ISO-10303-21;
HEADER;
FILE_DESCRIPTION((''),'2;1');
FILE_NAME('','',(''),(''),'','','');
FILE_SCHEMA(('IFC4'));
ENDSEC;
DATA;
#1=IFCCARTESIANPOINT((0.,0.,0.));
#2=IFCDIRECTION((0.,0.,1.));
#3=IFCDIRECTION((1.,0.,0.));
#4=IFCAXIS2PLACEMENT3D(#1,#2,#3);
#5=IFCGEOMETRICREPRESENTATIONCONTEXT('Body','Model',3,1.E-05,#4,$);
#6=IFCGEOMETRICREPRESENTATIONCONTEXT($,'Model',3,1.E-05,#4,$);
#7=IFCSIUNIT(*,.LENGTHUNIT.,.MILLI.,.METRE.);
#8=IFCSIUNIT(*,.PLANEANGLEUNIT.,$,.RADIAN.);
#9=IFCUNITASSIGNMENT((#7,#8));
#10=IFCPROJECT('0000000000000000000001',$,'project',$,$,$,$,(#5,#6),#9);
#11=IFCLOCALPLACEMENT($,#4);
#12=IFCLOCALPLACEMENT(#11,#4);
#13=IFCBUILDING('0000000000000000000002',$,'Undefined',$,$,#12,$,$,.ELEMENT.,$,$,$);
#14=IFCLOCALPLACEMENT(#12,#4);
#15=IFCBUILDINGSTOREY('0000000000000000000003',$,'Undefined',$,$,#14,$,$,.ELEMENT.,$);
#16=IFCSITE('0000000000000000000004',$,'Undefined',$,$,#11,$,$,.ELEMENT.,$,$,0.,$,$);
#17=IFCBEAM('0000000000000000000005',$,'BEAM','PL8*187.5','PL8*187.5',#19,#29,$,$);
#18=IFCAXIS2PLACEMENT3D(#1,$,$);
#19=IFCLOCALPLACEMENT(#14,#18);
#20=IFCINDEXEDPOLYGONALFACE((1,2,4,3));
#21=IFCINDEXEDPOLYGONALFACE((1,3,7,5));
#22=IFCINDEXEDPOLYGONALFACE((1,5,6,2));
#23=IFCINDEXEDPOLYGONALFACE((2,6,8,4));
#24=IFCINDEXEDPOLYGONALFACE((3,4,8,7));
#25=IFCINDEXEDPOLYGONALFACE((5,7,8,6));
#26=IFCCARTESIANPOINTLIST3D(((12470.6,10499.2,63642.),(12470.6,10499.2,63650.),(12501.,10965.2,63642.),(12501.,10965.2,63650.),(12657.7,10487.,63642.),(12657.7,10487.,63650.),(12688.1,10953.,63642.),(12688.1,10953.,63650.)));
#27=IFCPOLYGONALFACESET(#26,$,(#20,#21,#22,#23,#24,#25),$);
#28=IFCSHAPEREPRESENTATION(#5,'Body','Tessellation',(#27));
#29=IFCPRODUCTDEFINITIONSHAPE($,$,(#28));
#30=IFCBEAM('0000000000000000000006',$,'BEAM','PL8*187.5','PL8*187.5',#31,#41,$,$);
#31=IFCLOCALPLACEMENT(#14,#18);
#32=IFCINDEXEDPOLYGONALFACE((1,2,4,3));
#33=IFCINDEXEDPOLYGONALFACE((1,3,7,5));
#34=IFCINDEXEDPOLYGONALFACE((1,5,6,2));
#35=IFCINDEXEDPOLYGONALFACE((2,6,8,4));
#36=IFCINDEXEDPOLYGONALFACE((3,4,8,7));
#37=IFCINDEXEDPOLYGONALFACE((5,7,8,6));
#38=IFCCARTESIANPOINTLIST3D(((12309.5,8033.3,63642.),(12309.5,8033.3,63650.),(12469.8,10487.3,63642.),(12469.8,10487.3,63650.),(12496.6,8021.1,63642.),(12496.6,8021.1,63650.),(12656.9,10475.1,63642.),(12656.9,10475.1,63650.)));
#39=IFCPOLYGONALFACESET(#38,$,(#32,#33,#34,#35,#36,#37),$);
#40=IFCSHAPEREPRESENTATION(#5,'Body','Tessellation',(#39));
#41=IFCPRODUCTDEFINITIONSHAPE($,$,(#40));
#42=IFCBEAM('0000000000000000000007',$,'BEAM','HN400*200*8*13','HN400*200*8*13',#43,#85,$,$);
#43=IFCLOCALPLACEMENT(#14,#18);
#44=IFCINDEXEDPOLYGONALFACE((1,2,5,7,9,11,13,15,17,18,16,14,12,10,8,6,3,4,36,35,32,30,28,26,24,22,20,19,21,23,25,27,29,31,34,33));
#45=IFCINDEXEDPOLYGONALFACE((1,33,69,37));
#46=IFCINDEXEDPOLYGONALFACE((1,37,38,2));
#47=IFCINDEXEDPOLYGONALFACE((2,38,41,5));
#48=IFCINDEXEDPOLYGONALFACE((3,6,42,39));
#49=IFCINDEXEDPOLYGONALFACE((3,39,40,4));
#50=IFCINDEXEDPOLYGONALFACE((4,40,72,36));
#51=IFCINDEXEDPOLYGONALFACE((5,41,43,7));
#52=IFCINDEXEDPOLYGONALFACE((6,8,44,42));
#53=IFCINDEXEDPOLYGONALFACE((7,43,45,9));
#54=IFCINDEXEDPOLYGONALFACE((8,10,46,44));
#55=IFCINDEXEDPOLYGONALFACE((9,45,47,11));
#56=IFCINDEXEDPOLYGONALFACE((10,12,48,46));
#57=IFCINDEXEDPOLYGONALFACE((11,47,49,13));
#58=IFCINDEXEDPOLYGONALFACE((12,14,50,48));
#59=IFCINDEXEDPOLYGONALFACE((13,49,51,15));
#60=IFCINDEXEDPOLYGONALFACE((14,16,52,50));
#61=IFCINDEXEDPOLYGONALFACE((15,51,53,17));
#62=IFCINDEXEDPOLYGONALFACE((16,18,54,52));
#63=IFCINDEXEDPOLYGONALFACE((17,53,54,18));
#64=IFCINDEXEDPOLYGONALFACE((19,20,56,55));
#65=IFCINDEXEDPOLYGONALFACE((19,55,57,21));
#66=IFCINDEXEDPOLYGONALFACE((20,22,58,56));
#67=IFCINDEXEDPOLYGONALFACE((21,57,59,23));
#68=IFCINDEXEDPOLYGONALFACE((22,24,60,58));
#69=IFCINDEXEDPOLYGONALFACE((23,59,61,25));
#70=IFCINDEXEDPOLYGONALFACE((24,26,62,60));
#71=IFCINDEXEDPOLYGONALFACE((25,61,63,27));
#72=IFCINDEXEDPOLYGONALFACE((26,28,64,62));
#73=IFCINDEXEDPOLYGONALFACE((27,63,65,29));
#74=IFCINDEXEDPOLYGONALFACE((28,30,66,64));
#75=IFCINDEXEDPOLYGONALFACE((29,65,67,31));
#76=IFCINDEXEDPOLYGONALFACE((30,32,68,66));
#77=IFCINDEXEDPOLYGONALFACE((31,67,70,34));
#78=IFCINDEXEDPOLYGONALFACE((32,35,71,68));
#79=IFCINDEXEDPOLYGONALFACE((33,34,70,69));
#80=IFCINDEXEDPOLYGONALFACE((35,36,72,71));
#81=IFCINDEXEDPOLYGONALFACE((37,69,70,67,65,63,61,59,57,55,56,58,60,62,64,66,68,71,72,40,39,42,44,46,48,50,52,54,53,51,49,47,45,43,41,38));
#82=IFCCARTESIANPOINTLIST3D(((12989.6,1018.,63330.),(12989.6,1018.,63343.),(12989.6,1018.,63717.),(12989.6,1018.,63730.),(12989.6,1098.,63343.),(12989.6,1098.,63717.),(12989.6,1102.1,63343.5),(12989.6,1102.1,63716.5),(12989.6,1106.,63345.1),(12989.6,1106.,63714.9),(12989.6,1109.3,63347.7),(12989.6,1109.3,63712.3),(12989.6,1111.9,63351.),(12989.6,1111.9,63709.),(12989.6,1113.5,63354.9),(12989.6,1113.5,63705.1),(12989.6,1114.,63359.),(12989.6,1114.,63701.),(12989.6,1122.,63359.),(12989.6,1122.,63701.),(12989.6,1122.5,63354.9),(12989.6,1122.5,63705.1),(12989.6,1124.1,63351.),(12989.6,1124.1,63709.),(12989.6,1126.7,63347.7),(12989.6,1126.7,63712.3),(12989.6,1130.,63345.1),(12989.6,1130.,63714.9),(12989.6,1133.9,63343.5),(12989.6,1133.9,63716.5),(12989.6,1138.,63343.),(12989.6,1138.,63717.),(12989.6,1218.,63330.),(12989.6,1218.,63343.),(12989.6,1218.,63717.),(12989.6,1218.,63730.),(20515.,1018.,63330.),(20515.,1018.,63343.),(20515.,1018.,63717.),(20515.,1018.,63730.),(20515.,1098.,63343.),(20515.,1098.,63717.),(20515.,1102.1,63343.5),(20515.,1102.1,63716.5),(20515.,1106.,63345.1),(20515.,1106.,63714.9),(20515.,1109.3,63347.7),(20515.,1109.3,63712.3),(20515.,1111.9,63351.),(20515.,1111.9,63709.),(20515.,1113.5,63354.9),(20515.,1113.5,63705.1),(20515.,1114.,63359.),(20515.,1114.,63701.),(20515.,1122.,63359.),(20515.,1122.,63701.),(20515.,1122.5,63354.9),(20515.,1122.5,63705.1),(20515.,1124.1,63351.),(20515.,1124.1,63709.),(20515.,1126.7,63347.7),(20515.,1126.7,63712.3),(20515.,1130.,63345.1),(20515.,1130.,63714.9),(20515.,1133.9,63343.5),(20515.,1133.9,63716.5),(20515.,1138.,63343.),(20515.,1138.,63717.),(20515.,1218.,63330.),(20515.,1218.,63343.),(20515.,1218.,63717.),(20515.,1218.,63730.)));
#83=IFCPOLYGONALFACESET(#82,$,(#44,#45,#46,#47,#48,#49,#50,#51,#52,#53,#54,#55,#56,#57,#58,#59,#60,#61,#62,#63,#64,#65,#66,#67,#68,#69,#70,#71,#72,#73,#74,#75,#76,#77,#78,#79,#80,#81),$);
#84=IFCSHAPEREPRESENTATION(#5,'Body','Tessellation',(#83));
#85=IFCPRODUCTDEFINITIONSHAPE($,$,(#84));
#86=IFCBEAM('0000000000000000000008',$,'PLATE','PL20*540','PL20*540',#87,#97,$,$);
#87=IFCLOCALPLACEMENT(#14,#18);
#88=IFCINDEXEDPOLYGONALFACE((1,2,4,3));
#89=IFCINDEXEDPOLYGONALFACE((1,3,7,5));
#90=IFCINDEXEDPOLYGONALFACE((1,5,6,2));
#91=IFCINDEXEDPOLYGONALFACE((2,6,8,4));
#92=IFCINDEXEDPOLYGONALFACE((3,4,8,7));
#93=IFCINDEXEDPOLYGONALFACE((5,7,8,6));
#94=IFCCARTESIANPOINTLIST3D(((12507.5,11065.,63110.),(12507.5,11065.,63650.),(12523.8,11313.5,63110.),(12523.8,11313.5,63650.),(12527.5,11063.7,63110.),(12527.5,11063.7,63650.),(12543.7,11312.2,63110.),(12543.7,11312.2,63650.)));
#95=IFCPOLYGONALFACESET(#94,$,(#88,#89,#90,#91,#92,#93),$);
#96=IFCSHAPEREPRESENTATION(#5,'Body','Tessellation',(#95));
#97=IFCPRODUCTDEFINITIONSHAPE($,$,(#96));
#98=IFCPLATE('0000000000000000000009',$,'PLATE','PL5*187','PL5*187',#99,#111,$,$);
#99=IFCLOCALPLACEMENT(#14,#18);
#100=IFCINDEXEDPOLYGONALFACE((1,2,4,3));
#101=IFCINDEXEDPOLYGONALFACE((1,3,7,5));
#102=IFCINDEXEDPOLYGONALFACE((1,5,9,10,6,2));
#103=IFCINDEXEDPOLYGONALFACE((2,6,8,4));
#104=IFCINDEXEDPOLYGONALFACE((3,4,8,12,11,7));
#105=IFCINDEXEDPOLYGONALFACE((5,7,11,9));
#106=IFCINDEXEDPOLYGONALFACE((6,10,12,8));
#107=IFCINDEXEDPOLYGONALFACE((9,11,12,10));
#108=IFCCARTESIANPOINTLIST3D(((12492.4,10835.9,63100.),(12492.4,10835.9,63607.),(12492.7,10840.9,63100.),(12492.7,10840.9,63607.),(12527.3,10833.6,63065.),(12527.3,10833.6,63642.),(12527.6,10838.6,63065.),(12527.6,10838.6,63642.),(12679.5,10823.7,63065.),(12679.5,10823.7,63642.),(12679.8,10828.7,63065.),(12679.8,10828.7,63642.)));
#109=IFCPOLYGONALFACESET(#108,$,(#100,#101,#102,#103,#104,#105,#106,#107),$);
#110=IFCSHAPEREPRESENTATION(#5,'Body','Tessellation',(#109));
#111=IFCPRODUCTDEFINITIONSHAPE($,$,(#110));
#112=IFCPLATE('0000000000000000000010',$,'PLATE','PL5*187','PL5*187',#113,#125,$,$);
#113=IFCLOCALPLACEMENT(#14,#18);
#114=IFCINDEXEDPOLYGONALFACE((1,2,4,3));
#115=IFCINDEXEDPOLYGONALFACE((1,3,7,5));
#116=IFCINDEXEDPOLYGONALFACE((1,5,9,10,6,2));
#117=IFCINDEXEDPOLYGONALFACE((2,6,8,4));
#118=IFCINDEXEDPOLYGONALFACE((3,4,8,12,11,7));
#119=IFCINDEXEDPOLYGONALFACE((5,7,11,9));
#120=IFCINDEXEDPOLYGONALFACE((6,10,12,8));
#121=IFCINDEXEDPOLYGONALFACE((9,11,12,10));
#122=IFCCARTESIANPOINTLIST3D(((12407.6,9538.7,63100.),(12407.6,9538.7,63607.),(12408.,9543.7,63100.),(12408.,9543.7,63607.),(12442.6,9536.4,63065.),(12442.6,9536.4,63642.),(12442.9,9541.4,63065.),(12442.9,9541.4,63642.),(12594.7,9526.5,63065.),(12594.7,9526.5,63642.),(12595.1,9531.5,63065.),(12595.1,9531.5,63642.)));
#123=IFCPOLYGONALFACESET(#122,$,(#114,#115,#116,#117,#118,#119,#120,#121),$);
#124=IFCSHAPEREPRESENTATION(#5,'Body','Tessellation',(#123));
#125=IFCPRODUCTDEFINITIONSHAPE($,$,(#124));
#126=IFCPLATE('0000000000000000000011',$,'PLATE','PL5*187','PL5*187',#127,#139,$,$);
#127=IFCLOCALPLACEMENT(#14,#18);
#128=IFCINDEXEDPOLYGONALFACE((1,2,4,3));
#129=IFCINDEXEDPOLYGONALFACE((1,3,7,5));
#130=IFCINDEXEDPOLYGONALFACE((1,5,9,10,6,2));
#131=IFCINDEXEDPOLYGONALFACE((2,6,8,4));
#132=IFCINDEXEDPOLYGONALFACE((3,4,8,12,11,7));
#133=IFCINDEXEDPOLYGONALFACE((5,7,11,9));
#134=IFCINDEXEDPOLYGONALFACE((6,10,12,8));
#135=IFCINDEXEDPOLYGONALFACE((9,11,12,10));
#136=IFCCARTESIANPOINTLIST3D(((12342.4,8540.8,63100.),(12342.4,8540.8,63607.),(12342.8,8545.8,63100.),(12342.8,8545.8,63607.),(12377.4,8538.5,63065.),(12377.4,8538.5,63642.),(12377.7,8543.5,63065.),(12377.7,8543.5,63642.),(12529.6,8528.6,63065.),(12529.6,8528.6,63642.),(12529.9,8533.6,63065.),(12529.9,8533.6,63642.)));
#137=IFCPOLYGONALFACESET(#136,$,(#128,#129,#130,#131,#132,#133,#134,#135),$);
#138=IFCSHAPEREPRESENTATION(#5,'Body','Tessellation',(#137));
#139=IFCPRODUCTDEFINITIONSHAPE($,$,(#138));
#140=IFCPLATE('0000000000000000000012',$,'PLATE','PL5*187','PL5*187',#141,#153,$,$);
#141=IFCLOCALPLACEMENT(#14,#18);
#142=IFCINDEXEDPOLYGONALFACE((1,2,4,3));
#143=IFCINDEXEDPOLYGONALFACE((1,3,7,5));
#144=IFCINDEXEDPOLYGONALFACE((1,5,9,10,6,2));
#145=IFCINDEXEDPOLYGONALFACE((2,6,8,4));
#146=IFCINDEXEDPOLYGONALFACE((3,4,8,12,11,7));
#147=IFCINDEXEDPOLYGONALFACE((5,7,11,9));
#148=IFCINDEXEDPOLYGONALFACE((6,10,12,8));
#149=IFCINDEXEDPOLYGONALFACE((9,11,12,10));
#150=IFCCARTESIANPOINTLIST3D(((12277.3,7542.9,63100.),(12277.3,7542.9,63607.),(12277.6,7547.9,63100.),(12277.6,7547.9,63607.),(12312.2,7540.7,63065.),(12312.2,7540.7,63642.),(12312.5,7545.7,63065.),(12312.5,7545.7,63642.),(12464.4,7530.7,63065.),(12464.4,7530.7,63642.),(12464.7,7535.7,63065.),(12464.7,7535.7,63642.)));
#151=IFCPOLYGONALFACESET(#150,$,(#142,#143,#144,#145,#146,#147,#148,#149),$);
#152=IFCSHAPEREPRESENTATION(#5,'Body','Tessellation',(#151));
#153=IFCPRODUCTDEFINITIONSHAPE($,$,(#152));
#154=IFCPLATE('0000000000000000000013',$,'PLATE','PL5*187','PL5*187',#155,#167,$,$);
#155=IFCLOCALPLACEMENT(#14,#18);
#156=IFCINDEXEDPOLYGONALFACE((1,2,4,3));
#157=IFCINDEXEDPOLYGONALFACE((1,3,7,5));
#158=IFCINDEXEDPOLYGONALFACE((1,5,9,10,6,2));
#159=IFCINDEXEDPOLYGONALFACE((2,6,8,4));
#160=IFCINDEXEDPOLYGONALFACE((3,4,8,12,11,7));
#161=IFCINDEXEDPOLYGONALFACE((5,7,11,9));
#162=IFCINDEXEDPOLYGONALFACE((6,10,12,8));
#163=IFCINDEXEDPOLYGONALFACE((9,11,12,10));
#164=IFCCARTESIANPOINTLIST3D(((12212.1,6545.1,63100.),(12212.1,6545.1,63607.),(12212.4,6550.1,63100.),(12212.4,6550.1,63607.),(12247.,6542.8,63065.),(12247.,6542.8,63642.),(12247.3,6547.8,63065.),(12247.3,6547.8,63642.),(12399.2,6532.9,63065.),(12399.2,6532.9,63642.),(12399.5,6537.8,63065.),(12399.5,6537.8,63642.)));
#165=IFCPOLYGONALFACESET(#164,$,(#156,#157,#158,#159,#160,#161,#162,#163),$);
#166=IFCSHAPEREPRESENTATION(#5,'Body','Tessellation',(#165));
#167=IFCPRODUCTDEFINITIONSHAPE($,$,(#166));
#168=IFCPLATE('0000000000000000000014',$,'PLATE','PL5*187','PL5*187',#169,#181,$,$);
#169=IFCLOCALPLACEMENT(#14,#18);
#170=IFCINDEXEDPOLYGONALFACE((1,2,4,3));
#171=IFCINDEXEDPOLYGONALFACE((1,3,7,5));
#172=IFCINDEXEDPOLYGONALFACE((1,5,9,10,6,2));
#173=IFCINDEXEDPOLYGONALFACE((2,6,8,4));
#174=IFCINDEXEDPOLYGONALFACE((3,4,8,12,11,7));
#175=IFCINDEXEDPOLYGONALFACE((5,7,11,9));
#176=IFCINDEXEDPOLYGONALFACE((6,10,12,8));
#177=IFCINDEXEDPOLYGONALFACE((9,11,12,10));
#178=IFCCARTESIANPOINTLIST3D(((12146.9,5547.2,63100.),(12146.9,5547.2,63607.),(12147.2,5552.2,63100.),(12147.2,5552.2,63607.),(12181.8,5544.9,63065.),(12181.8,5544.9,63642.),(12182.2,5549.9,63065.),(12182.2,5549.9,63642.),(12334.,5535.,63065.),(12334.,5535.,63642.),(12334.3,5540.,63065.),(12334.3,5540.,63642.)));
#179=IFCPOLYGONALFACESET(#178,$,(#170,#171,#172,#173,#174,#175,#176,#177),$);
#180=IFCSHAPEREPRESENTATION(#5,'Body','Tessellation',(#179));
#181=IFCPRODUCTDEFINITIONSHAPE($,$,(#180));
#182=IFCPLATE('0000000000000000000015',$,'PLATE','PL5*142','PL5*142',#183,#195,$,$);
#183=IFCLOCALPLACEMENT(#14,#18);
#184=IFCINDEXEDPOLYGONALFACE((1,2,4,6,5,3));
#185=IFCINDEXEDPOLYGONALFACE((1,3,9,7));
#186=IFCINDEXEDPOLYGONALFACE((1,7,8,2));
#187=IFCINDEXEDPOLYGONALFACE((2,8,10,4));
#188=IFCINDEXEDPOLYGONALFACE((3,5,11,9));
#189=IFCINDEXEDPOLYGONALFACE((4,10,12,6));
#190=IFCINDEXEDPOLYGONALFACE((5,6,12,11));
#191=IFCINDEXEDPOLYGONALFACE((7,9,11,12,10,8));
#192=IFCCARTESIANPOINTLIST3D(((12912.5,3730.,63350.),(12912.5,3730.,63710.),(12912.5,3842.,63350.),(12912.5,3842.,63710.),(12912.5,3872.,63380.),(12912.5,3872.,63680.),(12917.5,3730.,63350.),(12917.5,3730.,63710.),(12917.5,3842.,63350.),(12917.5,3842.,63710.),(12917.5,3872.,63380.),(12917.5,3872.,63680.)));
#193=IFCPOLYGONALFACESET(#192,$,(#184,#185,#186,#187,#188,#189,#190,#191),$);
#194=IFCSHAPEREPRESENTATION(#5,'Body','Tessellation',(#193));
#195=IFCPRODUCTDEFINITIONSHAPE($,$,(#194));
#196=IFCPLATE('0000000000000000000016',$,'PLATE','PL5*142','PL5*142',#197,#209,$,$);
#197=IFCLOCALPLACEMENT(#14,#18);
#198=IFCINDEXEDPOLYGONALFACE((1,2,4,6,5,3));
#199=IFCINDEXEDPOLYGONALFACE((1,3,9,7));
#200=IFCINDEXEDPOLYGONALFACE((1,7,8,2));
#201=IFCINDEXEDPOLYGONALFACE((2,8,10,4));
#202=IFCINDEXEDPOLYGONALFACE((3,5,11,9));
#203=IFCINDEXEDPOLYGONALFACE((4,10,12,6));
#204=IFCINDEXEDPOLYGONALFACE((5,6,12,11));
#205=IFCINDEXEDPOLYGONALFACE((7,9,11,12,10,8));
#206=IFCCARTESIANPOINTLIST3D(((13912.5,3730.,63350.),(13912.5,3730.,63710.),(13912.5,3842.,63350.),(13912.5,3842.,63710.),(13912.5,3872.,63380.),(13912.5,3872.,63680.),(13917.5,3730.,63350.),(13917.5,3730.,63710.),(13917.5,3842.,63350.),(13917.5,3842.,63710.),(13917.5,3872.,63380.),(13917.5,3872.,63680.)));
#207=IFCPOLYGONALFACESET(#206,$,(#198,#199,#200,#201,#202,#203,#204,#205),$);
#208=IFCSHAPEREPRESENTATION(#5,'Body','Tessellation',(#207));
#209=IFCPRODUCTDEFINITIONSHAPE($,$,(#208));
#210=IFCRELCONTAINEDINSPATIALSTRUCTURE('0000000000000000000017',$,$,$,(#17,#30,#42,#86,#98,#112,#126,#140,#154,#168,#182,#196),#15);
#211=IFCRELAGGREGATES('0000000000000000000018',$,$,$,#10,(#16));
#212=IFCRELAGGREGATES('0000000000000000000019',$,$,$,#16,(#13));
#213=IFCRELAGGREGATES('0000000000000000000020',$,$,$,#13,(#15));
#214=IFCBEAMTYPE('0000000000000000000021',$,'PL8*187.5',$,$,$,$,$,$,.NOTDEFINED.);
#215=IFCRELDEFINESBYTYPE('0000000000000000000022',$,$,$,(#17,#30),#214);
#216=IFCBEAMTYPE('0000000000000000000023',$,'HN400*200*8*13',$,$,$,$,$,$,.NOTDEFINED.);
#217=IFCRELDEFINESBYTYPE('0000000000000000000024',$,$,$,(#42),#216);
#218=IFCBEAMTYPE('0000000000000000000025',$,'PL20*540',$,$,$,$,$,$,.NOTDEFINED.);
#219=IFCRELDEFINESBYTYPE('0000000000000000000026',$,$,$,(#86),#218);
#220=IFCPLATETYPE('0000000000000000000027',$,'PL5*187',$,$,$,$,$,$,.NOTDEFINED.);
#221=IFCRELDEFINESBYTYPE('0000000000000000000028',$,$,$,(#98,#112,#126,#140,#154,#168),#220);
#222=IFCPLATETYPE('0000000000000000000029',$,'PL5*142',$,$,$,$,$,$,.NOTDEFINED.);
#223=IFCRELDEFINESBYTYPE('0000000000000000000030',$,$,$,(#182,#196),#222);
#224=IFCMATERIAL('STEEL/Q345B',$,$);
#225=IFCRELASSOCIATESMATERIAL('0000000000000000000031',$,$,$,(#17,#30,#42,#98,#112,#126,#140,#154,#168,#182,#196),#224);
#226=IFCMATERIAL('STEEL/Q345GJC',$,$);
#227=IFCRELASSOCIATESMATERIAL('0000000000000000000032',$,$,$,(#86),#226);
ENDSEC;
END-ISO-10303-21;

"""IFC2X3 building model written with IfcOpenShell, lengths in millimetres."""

from ifc_helpers import new_model, si_unit, frame, origin_with_axes, origin_2d_with_axis, place, context, project, spatial, polyline, rectangle, i_section, outline, extrude, material, type_object, element, save


model = new_model("IFC2X3")

# Units and contexts
model_context_1 = context("Model", 3, precision=1e-05, world=origin_with_axes(), identifier="Body")
model_context_2 = context("Model", 3, precision=1e-05, world=origin_with_axes())
ifc_project = project(units=[si_unit("LENGTHUNIT", "METRE", prefix="MILLI"), si_unit("PLANEANGLEUNIT", "RADIAN")], contexts=[model_context_1, model_context_2])

# Site, building, storey
site_placement = place(None, origin_with_axes())
site = spatial("IfcSite", under=ifc_project, at=site_placement, Name="Undefined", CompositionType="ELEMENT", RefElevation=0.0)
building_placement = place(site_placement, origin_with_axes())
building = spatial("IfcBuilding", under=site, at=building_placement, Name="Undefined", CompositionType="ELEMENT")
storey_placement = place(building_placement, origin_with_axes())
storey = spatial("IfcBuildingStorey", under=building, at=storey_placement, Name="Undefined", CompositionType="ELEMENT")

# Beams
ifc_material_1 = material(Name="STEEL/Q345B")
beam_type_1 = type_object("IfcBeamType", Name="PL8*187.5", PredefinedType="NOTDEFINED")
beam_1_placement = place(storey_placement, frame((12564.1, 10493.1, 63646.0), z_axis=(-0.997873, 0.065184, 0.0), x_axis=(0.065184, 0.997873, 0.0)))
element("IfcBeam", 1, at=beam_1_placement, inside=storey, type_object=beam_type_1, material=ifc_material_1, Name="BEAM", Description="PL8*187.5", ObjectType="PL8*187.5", context=model_context_1, shape_type="SweptSolid", body=[
    extrude(rectangle(XDim=8.0, YDim=187.5, at=origin_2d_with_axis()), frame((466.9, 0.0, 0.0), z_axis=(-1.0, 0.0, 0.0), x_axis=(0.0, -1.0, 0.0)), (0.0, 0.0, 1.0), 466.9),
])
beam_2_placement = place(storey_placement, frame((12403.0, 8027.2, 63646.0), z_axis=(-0.997873, 0.065184, 0.0), x_axis=(0.065184, 0.997873, 0.0)))
element("IfcBeam", 2, at=beam_2_placement, inside=storey, type_object=beam_type_1, material=ifc_material_1, Name="BEAM", Description="PL8*187.5", ObjectType="PL8*187.5", context=model_context_1, shape_type="SweptSolid", body=[
    extrude(rectangle(XDim=8.0, YDim=187.5, at=origin_2d_with_axis()), frame((2459.2, 0.0, 0.0), z_axis=(-1.0, 0.0, 0.0), x_axis=(0.0, -1.0, 0.0)), (0.0, 0.0, 1.0), 2459.2),
])
beam_type_2 = type_object("IfcBeamType", Name="HN400*200*8*13", PredefinedType="NOTDEFINED")
beam_3_placement = place(storey_placement, frame((12832.3, 1118.0, 63530.0), z_axis=(0.0, 0.0, 1.0), x_axis=(1.0, 0.0, 0.0)))
element("IfcBeam", 3, at=beam_3_placement, inside=storey, type_object=beam_type_2, material=ifc_material_1, Name="BEAM", Description="HN400*200*8*13", ObjectType="HN400*200*8*13", context=model_context_1, shape_type="SweptSolid", body=[
    extrude(i_section(OverallWidth=200.0, OverallDepth=400.0, WebThickness=8.0, FlangeThickness=13.0, FilletRadius=16.0, at=origin_2d_with_axis()), frame((7682.7, 0.0, 0.0), z_axis=(-1.0, 0.0, 0.0), x_axis=(0.0, -1.0, 0.0)), (0.0, 0.0, 1.0), 7525.4),
])
ifc_material_2 = material(Name="STEEL/Q345GJC")
beam_type_3 = type_object("IfcBeamType", Name="PL20*540", PredefinedType="NOTDEFINED")
beam_4_placement = place(storey_placement, frame((12533.7, 11312.8, 63380.0), z_axis=(0.0, 0.0, 1.0), x_axis=(-0.065183, -0.997873, 0.0)))
element("IfcBeam", 4, at=beam_4_placement, inside=storey, type_object=beam_type_3, material=ifc_material_2, Name="PLATE", Description="PL20*540", ObjectType="PL20*540", context=model_context_1, shape_type="SweptSolid", body=[
    extrude(rectangle(XDim=20.0, YDim=540.0, at=origin_2d_with_axis()), frame((249.0, 0.0, 0.0), z_axis=(-1.0, 0.0, 0.0), x_axis=(0.0, -1.0, 0.0)), (0.0, 0.0, 1.0), 249.0),
])

# Plates
plate_type_1 = type_object("IfcPlateType", Name="PL5*187", PredefinedType="NOTDEFINED")
for number, where, z_axis, x_axis, name in (
    (5, (12679.6, 10826.2, 63642.0), (-0.065183, -0.997873, 0.0), (-0.997873, 0.065184, 0.0), "PLATE"),
    (6, (12594.9, 9529.0, 63642.0), (-0.065183, -0.997873, 0.0), (-0.997873, 0.065184, 0.0), "PLATE"),
    (7, (12529.7, 8531.1, 63642.0), (-0.065183, -0.997873, 0.0), (-0.997873, 0.065184, 0.0), "PLATE"),
    (8, (12464.5, 7533.2, 63642.0), (-0.065183, -0.997873, 0.0), (-0.997873, 0.065184, 0.0), "PLATE"),
    (9, (12399.4, 6535.4, 63642.0), (-0.065183, -0.997873, 0.0), (-0.997873, 0.065184, 0.0), "PLATE"),
    (10, (12334.2, 5537.5, 63642.0), (-0.065183, -0.997873, 0.0), (-0.997873, 0.065184, 0.0), "PLATE"),
):
    element("IfcPlate", number, at=place(storey_placement, frame(where, z_axis=z_axis, x_axis=x_axis)), inside=storey, type_object=plate_type_1, material=ifc_material_1, Name=name, Description="PL5*187", ObjectType="PL5*187", context=model_context_1, shape_type="SweptSolid", body=[
        extrude(outline(polyline([(0.0, 0.0), (152.5, 0.0), (187.5, 35.0), (187.5, 542.0), (152.5, 577.0), (0.0, 577.0), (0.0, 0.0)])), frame((0.0, 0.0, -2.5), z_axis=(0.0, 0.0, 1.0), x_axis=(1.0, 0.0, 0.0)), (0.0, 0.0, 1.0), 5.0),
    ])
plate_type_2 = type_object("IfcPlateType", Name="PL5*142", PredefinedType="NOTDEFINED")
for number, where, z_axis, x_axis, name in (
    (11, (12915.0, 3730.0, 63710.0), (-1.0, 0.0, 0.0), (0.0, 1.0, 0.0), "PLATE"),
    (12, (13915.0, 3730.0, 63710.0), (-1.0, 0.0, 0.0), (0.0, 1.0, 0.0), "PLATE"),
):
    element("IfcPlate", number, at=place(storey_placement, frame(where, z_axis=z_axis, x_axis=x_axis)), inside=storey, type_object=plate_type_2, material=ifc_material_1, Name=name, Description="PL5*142", ObjectType="PL5*142", context=model_context_1, shape_type="SweptSolid", body=[
        extrude(outline(polyline([(0.0, 0.0), (112.0, 0.0), (142.0, 30.0), (142.0, 330.0), (112.0, 360.0), (0.0, 360.0), (0.0, 0.0)])), frame((0.0, 0.0, -2.5), z_axis=(0.0, 0.0, 1.0), x_axis=(1.0, 0.0, 0.0)), (0.0, 0.0, 1.0), 5.0),
    ])

save(model, "model.ifc")
